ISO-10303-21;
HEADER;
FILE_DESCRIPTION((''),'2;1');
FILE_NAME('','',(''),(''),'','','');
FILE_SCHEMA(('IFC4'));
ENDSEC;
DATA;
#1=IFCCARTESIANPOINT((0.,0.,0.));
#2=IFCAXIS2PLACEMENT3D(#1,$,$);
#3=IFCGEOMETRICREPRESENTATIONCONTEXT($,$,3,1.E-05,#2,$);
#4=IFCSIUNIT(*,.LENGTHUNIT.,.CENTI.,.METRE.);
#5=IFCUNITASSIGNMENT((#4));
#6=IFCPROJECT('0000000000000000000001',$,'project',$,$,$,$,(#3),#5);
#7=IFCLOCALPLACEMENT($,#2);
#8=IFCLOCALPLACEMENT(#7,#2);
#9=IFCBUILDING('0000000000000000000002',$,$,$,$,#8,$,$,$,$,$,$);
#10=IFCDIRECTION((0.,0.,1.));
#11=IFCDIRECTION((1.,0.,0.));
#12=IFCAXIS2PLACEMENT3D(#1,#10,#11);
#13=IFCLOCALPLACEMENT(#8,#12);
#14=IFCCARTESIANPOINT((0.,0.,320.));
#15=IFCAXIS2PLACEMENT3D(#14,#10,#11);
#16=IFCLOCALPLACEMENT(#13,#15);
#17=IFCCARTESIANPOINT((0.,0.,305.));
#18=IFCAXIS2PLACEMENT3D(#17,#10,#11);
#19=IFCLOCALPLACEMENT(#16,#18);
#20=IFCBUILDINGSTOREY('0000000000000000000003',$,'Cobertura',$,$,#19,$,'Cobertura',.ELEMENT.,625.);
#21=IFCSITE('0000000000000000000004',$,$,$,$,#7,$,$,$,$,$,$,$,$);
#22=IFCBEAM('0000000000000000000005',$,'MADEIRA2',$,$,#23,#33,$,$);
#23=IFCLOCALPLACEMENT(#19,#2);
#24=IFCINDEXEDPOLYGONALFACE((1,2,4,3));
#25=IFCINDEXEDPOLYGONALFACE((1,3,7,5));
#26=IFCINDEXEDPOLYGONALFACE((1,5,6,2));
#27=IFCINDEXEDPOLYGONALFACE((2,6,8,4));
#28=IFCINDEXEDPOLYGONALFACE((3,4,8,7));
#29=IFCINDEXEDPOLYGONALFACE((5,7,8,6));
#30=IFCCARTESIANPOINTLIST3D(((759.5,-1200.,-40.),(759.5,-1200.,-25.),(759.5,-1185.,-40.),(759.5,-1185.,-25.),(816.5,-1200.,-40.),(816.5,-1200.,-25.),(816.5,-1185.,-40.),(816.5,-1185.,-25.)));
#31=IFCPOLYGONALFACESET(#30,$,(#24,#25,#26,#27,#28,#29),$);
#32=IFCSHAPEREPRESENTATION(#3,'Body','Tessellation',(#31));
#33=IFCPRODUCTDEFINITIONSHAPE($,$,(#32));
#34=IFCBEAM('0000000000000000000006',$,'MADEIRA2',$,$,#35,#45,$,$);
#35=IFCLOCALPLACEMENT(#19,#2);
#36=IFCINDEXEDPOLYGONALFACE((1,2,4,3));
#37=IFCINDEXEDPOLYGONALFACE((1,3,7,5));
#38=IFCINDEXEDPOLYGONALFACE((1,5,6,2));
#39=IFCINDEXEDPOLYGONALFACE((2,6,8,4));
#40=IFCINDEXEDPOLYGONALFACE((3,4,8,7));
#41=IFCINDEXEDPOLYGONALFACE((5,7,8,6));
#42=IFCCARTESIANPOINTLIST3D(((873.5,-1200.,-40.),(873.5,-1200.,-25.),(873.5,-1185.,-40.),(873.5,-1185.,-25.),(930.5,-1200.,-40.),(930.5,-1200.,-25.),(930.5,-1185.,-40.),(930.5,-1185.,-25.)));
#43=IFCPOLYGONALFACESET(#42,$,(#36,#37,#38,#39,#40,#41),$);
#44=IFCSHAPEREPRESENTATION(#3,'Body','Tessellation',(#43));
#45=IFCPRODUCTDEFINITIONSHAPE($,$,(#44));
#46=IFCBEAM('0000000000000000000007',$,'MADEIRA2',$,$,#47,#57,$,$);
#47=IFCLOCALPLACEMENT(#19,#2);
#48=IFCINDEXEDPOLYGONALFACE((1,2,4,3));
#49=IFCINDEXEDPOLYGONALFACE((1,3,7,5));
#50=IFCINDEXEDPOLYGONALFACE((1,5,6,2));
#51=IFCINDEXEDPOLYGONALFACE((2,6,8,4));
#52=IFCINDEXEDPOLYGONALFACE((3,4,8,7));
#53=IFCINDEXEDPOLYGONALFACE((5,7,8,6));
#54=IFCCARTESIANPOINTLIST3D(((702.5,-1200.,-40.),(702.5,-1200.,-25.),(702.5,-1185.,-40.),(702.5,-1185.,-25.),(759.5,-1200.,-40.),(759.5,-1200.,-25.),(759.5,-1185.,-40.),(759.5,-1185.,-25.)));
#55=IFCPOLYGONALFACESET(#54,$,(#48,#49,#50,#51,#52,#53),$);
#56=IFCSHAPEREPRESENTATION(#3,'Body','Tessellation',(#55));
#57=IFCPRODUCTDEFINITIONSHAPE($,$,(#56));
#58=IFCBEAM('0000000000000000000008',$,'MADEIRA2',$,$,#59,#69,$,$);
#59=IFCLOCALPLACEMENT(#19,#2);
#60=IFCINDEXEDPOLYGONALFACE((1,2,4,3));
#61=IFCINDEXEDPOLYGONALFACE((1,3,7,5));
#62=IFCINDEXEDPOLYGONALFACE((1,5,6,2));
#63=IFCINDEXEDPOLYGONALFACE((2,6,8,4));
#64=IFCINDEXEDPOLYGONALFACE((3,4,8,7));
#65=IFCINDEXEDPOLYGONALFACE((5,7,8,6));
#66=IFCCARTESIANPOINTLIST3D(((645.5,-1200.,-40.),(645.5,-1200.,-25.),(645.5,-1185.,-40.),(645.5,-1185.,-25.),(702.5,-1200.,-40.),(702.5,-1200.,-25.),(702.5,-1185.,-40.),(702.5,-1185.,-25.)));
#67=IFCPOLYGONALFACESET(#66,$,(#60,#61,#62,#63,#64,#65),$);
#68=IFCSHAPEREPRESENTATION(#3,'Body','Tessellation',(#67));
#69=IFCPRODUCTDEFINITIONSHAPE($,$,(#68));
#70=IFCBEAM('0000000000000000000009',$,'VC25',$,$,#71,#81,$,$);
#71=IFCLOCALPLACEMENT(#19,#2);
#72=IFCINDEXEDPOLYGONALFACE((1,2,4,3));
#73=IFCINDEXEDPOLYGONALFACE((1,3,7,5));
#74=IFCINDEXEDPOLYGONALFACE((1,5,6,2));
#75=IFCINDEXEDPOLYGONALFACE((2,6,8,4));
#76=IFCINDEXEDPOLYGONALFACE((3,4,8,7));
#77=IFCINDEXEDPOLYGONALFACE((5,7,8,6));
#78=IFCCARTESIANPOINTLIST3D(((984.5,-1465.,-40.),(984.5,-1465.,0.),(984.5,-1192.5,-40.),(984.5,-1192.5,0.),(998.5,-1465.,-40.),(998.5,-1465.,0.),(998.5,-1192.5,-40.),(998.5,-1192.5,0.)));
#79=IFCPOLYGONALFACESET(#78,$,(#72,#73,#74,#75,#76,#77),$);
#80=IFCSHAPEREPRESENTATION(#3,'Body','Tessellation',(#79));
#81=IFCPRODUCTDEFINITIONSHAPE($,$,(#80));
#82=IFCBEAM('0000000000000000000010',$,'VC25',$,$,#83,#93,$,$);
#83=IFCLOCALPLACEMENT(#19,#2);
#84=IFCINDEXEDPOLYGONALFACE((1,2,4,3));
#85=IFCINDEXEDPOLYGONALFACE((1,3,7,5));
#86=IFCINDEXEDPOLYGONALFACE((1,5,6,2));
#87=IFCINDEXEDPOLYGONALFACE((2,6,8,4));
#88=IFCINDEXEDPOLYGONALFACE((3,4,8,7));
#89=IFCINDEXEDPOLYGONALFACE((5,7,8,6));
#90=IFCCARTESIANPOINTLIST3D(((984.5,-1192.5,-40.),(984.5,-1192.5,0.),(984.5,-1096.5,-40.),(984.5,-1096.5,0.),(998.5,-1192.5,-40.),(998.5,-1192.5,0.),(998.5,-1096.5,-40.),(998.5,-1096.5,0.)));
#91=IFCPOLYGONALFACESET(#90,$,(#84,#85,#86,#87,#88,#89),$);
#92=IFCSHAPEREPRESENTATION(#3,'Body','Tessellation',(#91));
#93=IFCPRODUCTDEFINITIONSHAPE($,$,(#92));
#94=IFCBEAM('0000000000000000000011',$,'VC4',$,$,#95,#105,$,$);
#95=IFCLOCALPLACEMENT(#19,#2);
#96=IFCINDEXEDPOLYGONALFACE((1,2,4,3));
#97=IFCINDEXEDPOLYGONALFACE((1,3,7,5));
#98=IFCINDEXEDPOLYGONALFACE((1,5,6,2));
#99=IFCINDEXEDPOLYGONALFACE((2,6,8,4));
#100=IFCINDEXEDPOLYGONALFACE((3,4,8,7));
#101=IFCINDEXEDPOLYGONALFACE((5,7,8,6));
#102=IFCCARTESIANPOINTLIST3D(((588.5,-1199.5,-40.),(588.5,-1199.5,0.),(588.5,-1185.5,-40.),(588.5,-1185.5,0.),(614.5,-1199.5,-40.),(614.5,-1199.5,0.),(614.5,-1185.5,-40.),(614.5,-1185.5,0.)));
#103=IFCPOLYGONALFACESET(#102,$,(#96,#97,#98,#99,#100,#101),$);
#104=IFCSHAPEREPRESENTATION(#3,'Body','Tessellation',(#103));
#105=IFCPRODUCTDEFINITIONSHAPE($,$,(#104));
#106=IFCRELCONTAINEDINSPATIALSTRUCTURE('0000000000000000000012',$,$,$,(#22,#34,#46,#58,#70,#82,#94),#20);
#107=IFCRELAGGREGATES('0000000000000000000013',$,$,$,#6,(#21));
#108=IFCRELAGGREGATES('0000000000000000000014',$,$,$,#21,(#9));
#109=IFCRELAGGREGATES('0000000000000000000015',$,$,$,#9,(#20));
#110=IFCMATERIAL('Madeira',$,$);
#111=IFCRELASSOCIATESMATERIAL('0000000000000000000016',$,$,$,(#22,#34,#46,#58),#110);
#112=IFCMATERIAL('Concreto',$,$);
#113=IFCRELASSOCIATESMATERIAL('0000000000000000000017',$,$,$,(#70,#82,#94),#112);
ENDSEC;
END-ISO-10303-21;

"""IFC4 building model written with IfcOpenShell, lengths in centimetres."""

from ifc_helpers import new_model, si_unit, frame, origin, origin_with_axes, place, context, project, spatial, polyline, outline, extrude, material, element, save


model = new_model("IFC4")

# Units and contexts
context_of_model = context(None, 3, precision=1e-05, world=origin())
ifc_project = project(units=[si_unit("LENGTHUNIT", "METRE", prefix="CENTI")], contexts=[context_of_model])

# Site, building, storey
site_placement = place(None, origin())
site = spatial("IfcSite", under=ifc_project, at=site_placement)
building_placement = place(site_placement, origin())
building = spatial("IfcBuilding", under=site, at=building_placement)
placement_1 = place(building_placement, origin_with_axes())
placement_2 = place(placement_1, frame((0.0, 0.0, 320.0), z_axis=(0.0, 0.0, 1.0), x_axis=(1.0, 0.0, 0.0)))
storey_placement = place(placement_2, frame((0.0, 0.0, 305.0), z_axis=(0.0, 0.0, 1.0), x_axis=(1.0, 0.0, 0.0)))
storey = spatial("IfcBuildingStorey", under=building, at=storey_placement, Name="Cobertura", LongName="Cobertura", CompositionType="ELEMENT", Elevation=625.0)

# Shared definitions
ifc_material_1 = material(Name="Concreto")

# Beams
ifc_material_2 = material(Name="Madeira")
for number, where, z_axis, x_axis, name in (
    (1, (788.0, -1192.5, -25.0), (0.0, 0.0, 1.0), (1.0, 0.0, 0.0), "MADEIRA2"),
    (2, (902.0, -1192.5, -25.0), (0.0, 0.0, 1.0), (1.0, 0.0, 0.0), "MADEIRA2"),
    (3, (731.0, -1192.5, -25.0), (0.0, 0.0, 1.0), (1.0, 0.0, 0.0), "MADEIRA2"),
    (4, (674.0, -1192.5, -25.0), (0.0, 0.0, 1.0), (1.0, 0.0, 0.0), "MADEIRA2"),
):
    element("IfcBeam", number, at=place(storey_placement, frame(where, z_axis=z_axis, x_axis=x_axis)), inside=storey, material=ifc_material_2, Name=name, context=context_of_model, shape_type="SolidModel", body=[
        extrude(outline(polyline([(-7.5, -7.5), (-7.5, 7.5), (7.5, 7.5), (7.5, -7.5), (-7.5, -7.5)])), frame((-28.5, 0.0, -7.5), z_axis=(1.0, 0.0, 0.0), x_axis=(0.0, -1.0, 0.0)), (0.0, 0.0, 1.0), 57.0),
    ])
beam_1_placement = place(storey_placement, frame((991.5, -1328.75, 0.0), z_axis=(0.0, 0.0, 1.0), x_axis=(1.0, 0.0, 0.0)))
element("IfcBeam", 5, at=beam_1_placement, inside=storey, material=ifc_material_1, Name="VC25", context=context_of_model, shape_type="SolidModel", body=[
    extrude(outline(polyline([(-7.0, -20.0), (7.0, -20.0), (7.0, 20.0), (-7.0, 20.0), (-7.0, -20.0)])), frame((0.0, -136.25, -20.0), z_axis=(0.0, 1.0, 0.0), x_axis=(1.0, 0.0, 0.0)), (0.0, 0.0, 1.0), 272.5),
])
beam_2_placement = place(storey_placement, frame((991.5, -1144.5, 0.0), z_axis=(0.0, 0.0, 1.0), x_axis=(1.0, 0.0, 0.0)))
element("IfcBeam", 6, at=beam_2_placement, inside=storey, material=ifc_material_1, Name="VC25", context=context_of_model, shape_type="SolidModel", body=[
    extrude(outline(polyline([(-7.0, -20.0), (7.0, -20.0), (7.0, 20.0), (-7.0, 20.0), (-7.0, -20.0)])), frame((0.0, -48.0, -20.0), z_axis=(0.0, 1.0, 0.0), x_axis=(1.0, 0.0, 0.0)), (0.0, 0.0, 1.0), 96.0),
])
beam_3_placement = place(storey_placement, frame((601.5, -1192.5, 0.0), z_axis=(0.0, 0.0, 1.0), x_axis=(1.0, 0.0, 0.0)))
element("IfcBeam", 7, at=beam_3_placement, inside=storey, material=ifc_material_1, Name="VC4", context=context_of_model, shape_type="SolidModel", body=[
    extrude(outline(polyline([(-7.0, -20.0), (7.0, -20.0), (7.0, 20.0), (-7.0, 20.0), (-7.0, -20.0)])), frame((-13.0, 0.0, -20.0), z_axis=(1.0, 0.0, 0.0), x_axis=(0.0, -1.0, 0.0)), (0.0, 0.0, 1.0), 26.0),
])

save(model, "model.ifc")
